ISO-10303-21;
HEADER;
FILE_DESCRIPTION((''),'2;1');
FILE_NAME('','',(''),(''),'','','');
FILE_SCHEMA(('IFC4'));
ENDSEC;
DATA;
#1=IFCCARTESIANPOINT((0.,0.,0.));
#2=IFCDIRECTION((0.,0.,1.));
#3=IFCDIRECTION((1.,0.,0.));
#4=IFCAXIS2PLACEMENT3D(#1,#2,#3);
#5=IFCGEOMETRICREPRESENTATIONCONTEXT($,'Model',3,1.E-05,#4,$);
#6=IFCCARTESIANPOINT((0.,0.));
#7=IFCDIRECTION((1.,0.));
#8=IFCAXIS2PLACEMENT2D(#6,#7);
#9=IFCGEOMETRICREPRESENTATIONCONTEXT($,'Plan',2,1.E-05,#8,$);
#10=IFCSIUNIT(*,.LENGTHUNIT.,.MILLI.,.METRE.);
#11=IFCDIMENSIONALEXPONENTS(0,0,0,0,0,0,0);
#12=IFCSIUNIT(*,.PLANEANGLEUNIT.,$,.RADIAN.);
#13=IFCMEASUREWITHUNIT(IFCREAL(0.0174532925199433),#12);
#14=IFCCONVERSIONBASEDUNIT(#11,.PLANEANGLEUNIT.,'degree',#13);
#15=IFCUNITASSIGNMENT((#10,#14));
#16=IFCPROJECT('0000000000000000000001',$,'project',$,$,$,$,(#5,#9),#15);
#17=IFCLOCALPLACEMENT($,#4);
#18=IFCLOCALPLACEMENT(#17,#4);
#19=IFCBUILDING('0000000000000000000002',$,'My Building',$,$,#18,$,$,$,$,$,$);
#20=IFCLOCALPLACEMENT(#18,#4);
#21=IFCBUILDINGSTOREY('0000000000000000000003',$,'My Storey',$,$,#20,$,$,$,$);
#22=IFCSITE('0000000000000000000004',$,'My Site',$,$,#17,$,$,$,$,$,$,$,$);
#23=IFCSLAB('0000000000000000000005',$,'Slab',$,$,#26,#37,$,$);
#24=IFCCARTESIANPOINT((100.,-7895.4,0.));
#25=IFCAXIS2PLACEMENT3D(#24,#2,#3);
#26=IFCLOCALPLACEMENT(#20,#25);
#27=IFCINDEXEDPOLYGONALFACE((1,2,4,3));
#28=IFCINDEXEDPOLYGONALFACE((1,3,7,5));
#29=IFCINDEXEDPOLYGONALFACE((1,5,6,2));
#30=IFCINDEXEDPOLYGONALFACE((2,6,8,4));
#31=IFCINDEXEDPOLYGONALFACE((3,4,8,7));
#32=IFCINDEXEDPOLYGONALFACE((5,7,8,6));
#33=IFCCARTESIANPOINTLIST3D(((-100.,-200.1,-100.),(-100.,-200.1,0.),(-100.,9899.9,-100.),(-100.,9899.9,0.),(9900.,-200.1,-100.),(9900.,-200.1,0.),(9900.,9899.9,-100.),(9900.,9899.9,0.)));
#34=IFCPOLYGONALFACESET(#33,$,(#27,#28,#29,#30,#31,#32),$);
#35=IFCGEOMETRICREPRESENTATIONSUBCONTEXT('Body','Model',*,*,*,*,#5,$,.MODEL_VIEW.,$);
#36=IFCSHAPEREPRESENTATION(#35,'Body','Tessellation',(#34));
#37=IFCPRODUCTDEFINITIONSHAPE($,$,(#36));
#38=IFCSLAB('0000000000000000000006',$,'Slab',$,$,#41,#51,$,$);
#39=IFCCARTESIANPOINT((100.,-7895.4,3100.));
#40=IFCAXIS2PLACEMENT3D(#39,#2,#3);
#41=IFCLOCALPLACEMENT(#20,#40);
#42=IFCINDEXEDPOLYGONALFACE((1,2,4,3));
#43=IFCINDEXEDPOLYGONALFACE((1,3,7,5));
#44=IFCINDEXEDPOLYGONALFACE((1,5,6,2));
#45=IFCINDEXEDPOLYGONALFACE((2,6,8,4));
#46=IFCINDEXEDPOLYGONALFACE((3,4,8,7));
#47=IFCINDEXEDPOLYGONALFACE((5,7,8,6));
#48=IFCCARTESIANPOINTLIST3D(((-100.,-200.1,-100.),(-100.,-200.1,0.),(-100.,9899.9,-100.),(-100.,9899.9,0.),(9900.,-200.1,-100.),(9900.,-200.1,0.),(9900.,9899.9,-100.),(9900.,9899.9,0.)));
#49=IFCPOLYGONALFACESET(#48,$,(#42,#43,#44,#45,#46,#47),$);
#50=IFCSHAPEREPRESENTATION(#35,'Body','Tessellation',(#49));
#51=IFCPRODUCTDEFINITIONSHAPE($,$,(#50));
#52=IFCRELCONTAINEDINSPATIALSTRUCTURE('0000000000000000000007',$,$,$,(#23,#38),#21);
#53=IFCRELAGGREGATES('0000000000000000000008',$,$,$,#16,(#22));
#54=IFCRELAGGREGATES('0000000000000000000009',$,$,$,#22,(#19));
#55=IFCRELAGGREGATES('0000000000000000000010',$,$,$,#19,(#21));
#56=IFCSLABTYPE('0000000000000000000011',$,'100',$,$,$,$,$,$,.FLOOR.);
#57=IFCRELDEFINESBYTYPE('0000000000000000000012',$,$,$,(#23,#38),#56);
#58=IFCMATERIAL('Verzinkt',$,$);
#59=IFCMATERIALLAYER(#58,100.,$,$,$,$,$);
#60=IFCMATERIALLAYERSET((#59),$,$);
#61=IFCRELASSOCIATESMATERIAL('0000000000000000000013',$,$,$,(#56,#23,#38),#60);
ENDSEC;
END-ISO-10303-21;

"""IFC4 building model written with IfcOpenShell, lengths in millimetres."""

from ifc_helpers import new_model, entity, si_unit, converted_unit, frame, origin_with_axes, origin_2d_with_axis, place, context, subcontext, project, spatial, indexed_curve, outline, extrude, material, layer, layer_set, layer_usage, type_object, element, save


model = new_model("IFC4")

# Units and contexts
model_context = context("Model", 3, precision=1e-05, world=origin_with_axes())
plan_context = context("Plan", 2, precision=1e-05, world=origin_2d_with_axis())
body_context = subcontext(model_context, "Body", "Model", "MODEL_VIEW")
ifc_project = project(units=[si_unit("LENGTHUNIT", "METRE", prefix="MILLI"), converted_unit("PLANEANGLEUNIT", "degree", entity("IfcReal", 0.0174532925199433), si_unit("PLANEANGLEUNIT", "RADIAN"), dimensions=[0, 0, 0, 0, 0, 0, 0])], contexts=[model_context, plan_context])

# Site, building, storey
site_placement = place(None, origin_with_axes())
site = spatial("IfcSite", under=ifc_project, at=site_placement, Name="My Site")
building_placement = place(site_placement, origin_with_axes())
building = spatial("IfcBuilding", under=site, at=building_placement, Name="My Building")
storey_placement = place(building_placement, origin_with_axes())
storey = spatial("IfcBuildingStorey", under=building, at=storey_placement, Name="My Storey")

# Slabs
ifc_material = material(Name="Verzinkt")
ifc_layer_1 = layer(ifc_material, 100.0)
ifc_layer_set_1 = layer_set([ifc_layer_1])
ifc_layer_usage_1 = layer_usage(ifc_layer_set_1, "AXIS3", "POSITIVE", -100.0)
slab_type = type_object("IfcSlabType", Name="100", PredefinedType="FLOOR", material=ifc_layer_set_1)
slab_1_placement = place(storey_placement, frame((100.0, -7895.4, 0.0), z_axis=(0.0, 0.0, 1.0), x_axis=(1.0, 0.0, 0.0)))
element("IfcSlab", 1, at=slab_1_placement, inside=storey, type_object=slab_type, material=ifc_layer_usage_1, Name="Slab", context=body_context, shape_type="SweptSolid", body=[
    extrude(outline(indexed_curve([(-100.0, 9899.9), (9900.0, 9899.9), (9900.0, -200.1), (-100.0, -200.1), (-100.0, 9899.9)])), frame((0.0, 0.0, -100.0), z_axis=(0.0, 0.0, 1.0), x_axis=(1.0, 0.0, 0.0)), (0.0, 0.0, 1.0), 100.0),
])
ifc_layer_usage_2 = layer_usage(ifc_layer_set_1, "AXIS3", "POSITIVE", -100.0)
slab_2_placement = place(storey_placement, frame((100.0, -7895.4, 3100.0), z_axis=(0.0, 0.0, 1.0), x_axis=(1.0, 0.0, 0.0)))
element("IfcSlab", 2, at=slab_2_placement, inside=storey, type_object=slab_type, material=ifc_layer_usage_2, Name="Slab", context=body_context, shape_type="SweptSolid", body=[
    extrude(outline(indexed_curve([(-100.0, 9899.9), (9900.0, 9899.9), (9900.0, -200.1), (-100.0, -200.1), (-100.0, 9899.9)])), frame((0.0, 0.0, -100.0), z_axis=(0.0, 0.0, 1.0), x_axis=(1.0, 0.0, 0.0)), (0.0, 0.0, 1.0), 100.0),
])

save(model, "model.ifc")
